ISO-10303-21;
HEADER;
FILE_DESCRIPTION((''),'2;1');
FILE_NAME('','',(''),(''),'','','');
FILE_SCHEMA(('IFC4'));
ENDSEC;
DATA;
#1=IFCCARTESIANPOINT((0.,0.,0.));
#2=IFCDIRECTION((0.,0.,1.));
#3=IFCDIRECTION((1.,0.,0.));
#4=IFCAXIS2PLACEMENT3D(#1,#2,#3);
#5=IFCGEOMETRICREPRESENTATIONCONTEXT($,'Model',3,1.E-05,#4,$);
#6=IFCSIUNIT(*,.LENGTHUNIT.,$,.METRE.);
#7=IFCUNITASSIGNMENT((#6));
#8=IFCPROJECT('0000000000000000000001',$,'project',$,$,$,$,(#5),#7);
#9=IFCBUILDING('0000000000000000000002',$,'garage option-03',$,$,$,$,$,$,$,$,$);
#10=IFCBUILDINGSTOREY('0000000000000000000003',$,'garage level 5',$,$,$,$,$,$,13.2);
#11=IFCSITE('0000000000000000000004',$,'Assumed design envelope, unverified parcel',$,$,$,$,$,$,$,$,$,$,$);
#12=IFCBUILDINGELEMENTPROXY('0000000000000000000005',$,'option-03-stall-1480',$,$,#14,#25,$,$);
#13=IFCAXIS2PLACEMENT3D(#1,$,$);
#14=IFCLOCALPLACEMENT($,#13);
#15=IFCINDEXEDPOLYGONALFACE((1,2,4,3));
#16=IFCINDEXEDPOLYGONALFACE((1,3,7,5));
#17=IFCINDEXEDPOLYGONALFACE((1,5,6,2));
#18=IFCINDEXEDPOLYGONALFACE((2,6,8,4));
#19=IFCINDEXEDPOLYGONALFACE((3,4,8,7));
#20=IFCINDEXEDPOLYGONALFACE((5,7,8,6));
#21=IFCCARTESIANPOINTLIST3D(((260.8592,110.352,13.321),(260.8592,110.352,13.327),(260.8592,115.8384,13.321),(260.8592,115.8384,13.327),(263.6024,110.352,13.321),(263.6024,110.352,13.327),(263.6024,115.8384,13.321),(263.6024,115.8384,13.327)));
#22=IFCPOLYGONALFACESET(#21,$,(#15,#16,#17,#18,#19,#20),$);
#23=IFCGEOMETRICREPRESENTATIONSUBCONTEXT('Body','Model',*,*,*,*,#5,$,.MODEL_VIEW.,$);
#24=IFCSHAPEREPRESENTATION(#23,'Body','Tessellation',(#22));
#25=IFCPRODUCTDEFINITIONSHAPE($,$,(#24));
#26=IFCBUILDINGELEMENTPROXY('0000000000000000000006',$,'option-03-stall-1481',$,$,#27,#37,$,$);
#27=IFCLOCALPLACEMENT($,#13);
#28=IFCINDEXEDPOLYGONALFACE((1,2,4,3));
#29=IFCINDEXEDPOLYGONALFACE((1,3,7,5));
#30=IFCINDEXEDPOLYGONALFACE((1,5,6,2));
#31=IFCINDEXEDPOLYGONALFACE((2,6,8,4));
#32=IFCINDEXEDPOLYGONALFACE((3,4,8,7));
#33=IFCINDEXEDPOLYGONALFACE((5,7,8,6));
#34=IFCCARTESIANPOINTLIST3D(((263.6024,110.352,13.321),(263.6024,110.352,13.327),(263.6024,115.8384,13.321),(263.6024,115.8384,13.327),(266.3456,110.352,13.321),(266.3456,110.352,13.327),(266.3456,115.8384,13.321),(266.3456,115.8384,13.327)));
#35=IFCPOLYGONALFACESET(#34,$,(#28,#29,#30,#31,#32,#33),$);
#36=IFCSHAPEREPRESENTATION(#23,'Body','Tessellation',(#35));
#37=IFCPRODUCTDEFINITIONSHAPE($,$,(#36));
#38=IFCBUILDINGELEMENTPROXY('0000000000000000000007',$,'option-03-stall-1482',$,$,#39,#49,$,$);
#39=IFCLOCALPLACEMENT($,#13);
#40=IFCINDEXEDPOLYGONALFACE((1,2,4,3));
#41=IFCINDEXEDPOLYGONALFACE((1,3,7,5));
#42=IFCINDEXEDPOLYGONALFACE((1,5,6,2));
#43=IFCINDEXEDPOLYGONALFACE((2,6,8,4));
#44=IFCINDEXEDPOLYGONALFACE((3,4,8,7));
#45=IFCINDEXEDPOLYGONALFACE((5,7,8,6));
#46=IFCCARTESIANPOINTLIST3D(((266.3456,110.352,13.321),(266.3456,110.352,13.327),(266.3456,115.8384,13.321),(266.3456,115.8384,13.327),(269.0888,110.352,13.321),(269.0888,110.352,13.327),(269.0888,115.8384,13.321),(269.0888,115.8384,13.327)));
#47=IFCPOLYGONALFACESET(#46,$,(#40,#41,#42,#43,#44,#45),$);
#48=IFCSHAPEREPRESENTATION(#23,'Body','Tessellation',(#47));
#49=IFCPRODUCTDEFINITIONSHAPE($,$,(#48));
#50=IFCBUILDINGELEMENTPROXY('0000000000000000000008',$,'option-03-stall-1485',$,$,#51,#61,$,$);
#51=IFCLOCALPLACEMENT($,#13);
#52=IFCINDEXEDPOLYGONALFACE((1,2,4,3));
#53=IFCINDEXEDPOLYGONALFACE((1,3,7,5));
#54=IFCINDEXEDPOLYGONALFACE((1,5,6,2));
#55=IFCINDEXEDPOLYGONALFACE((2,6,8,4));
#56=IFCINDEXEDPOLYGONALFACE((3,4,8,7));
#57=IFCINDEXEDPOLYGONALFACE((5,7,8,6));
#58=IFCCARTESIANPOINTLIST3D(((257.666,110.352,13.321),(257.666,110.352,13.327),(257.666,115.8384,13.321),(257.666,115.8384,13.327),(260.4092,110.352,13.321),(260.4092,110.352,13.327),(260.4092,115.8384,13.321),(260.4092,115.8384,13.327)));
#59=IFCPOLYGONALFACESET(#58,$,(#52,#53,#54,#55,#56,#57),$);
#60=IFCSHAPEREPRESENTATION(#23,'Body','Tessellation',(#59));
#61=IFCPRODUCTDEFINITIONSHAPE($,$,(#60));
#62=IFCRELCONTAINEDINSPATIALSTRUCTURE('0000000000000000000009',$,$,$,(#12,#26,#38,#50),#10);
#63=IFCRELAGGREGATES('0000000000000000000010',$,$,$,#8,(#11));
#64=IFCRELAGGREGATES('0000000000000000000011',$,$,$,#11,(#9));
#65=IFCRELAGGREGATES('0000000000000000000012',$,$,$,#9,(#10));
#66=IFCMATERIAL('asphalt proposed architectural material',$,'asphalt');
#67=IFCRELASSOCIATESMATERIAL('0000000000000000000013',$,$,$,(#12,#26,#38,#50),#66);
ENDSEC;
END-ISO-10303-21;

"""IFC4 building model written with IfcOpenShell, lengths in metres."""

from ifc_helpers import new_model, si_unit, frame, origin_with_axes, place, context, subcontext, project, spatial, rectangle, extrude, material, element, save


model = new_model("IFC4")

# Units and contexts
model_context = context("Model", 3, precision=1e-05, world=origin_with_axes())
body_context = subcontext(model_context, "Body", "Model", "MODEL_VIEW")
ifc_project = project(units=[si_unit("LENGTHUNIT", "METRE")], contexts=[model_context])

# Site, building, storey
site = spatial("IfcSite", under=ifc_project, Name="Assumed design envelope, unverified parcel")
building = spatial("IfcBuilding", under=site, Name="garage option-03")
storey = spatial("IfcBuildingStorey", under=building, Name="garage level 5", Elevation=13.2)

# Building element proxies
ifc_material_1 = material(Name="asphalt proposed architectural material", Category="asphalt")
for number, where, z_axis, x_axis, name in (
    (1, (262.2308, 113.0952, 13.321), (0.0, 0.0, 1.0), (1.0, 0.0, 0.0), "option-03-stall-1480"),
    (2, (264.974, 113.0952, 13.321), (0.0, 0.0, 1.0), (1.0, 0.0, 0.0), "option-03-stall-1481"),
    (3, (267.7172, 113.0952, 13.321), (0.0, 0.0, 1.0), (1.0, 0.0, 0.0), "option-03-stall-1482"),
    (4, (259.0376, 113.0952, 13.321), (0.0, 0.0, 1.0), (1.0, 0.0, 0.0), "option-03-stall-1485"),
):
    element("IfcBuildingElementProxy", number, at=place(None, frame(where, z_axis=z_axis, x_axis=x_axis)), inside=storey, material=ifc_material_1, Name=name, context=body_context, shape_type="SweptSolid", body=[
        extrude(rectangle(XDim=2.7432, YDim=5.4864), origin_with_axes(), (0.0, 0.0, 1.0), 0.006),
    ])

save(model, "model.ifc")
